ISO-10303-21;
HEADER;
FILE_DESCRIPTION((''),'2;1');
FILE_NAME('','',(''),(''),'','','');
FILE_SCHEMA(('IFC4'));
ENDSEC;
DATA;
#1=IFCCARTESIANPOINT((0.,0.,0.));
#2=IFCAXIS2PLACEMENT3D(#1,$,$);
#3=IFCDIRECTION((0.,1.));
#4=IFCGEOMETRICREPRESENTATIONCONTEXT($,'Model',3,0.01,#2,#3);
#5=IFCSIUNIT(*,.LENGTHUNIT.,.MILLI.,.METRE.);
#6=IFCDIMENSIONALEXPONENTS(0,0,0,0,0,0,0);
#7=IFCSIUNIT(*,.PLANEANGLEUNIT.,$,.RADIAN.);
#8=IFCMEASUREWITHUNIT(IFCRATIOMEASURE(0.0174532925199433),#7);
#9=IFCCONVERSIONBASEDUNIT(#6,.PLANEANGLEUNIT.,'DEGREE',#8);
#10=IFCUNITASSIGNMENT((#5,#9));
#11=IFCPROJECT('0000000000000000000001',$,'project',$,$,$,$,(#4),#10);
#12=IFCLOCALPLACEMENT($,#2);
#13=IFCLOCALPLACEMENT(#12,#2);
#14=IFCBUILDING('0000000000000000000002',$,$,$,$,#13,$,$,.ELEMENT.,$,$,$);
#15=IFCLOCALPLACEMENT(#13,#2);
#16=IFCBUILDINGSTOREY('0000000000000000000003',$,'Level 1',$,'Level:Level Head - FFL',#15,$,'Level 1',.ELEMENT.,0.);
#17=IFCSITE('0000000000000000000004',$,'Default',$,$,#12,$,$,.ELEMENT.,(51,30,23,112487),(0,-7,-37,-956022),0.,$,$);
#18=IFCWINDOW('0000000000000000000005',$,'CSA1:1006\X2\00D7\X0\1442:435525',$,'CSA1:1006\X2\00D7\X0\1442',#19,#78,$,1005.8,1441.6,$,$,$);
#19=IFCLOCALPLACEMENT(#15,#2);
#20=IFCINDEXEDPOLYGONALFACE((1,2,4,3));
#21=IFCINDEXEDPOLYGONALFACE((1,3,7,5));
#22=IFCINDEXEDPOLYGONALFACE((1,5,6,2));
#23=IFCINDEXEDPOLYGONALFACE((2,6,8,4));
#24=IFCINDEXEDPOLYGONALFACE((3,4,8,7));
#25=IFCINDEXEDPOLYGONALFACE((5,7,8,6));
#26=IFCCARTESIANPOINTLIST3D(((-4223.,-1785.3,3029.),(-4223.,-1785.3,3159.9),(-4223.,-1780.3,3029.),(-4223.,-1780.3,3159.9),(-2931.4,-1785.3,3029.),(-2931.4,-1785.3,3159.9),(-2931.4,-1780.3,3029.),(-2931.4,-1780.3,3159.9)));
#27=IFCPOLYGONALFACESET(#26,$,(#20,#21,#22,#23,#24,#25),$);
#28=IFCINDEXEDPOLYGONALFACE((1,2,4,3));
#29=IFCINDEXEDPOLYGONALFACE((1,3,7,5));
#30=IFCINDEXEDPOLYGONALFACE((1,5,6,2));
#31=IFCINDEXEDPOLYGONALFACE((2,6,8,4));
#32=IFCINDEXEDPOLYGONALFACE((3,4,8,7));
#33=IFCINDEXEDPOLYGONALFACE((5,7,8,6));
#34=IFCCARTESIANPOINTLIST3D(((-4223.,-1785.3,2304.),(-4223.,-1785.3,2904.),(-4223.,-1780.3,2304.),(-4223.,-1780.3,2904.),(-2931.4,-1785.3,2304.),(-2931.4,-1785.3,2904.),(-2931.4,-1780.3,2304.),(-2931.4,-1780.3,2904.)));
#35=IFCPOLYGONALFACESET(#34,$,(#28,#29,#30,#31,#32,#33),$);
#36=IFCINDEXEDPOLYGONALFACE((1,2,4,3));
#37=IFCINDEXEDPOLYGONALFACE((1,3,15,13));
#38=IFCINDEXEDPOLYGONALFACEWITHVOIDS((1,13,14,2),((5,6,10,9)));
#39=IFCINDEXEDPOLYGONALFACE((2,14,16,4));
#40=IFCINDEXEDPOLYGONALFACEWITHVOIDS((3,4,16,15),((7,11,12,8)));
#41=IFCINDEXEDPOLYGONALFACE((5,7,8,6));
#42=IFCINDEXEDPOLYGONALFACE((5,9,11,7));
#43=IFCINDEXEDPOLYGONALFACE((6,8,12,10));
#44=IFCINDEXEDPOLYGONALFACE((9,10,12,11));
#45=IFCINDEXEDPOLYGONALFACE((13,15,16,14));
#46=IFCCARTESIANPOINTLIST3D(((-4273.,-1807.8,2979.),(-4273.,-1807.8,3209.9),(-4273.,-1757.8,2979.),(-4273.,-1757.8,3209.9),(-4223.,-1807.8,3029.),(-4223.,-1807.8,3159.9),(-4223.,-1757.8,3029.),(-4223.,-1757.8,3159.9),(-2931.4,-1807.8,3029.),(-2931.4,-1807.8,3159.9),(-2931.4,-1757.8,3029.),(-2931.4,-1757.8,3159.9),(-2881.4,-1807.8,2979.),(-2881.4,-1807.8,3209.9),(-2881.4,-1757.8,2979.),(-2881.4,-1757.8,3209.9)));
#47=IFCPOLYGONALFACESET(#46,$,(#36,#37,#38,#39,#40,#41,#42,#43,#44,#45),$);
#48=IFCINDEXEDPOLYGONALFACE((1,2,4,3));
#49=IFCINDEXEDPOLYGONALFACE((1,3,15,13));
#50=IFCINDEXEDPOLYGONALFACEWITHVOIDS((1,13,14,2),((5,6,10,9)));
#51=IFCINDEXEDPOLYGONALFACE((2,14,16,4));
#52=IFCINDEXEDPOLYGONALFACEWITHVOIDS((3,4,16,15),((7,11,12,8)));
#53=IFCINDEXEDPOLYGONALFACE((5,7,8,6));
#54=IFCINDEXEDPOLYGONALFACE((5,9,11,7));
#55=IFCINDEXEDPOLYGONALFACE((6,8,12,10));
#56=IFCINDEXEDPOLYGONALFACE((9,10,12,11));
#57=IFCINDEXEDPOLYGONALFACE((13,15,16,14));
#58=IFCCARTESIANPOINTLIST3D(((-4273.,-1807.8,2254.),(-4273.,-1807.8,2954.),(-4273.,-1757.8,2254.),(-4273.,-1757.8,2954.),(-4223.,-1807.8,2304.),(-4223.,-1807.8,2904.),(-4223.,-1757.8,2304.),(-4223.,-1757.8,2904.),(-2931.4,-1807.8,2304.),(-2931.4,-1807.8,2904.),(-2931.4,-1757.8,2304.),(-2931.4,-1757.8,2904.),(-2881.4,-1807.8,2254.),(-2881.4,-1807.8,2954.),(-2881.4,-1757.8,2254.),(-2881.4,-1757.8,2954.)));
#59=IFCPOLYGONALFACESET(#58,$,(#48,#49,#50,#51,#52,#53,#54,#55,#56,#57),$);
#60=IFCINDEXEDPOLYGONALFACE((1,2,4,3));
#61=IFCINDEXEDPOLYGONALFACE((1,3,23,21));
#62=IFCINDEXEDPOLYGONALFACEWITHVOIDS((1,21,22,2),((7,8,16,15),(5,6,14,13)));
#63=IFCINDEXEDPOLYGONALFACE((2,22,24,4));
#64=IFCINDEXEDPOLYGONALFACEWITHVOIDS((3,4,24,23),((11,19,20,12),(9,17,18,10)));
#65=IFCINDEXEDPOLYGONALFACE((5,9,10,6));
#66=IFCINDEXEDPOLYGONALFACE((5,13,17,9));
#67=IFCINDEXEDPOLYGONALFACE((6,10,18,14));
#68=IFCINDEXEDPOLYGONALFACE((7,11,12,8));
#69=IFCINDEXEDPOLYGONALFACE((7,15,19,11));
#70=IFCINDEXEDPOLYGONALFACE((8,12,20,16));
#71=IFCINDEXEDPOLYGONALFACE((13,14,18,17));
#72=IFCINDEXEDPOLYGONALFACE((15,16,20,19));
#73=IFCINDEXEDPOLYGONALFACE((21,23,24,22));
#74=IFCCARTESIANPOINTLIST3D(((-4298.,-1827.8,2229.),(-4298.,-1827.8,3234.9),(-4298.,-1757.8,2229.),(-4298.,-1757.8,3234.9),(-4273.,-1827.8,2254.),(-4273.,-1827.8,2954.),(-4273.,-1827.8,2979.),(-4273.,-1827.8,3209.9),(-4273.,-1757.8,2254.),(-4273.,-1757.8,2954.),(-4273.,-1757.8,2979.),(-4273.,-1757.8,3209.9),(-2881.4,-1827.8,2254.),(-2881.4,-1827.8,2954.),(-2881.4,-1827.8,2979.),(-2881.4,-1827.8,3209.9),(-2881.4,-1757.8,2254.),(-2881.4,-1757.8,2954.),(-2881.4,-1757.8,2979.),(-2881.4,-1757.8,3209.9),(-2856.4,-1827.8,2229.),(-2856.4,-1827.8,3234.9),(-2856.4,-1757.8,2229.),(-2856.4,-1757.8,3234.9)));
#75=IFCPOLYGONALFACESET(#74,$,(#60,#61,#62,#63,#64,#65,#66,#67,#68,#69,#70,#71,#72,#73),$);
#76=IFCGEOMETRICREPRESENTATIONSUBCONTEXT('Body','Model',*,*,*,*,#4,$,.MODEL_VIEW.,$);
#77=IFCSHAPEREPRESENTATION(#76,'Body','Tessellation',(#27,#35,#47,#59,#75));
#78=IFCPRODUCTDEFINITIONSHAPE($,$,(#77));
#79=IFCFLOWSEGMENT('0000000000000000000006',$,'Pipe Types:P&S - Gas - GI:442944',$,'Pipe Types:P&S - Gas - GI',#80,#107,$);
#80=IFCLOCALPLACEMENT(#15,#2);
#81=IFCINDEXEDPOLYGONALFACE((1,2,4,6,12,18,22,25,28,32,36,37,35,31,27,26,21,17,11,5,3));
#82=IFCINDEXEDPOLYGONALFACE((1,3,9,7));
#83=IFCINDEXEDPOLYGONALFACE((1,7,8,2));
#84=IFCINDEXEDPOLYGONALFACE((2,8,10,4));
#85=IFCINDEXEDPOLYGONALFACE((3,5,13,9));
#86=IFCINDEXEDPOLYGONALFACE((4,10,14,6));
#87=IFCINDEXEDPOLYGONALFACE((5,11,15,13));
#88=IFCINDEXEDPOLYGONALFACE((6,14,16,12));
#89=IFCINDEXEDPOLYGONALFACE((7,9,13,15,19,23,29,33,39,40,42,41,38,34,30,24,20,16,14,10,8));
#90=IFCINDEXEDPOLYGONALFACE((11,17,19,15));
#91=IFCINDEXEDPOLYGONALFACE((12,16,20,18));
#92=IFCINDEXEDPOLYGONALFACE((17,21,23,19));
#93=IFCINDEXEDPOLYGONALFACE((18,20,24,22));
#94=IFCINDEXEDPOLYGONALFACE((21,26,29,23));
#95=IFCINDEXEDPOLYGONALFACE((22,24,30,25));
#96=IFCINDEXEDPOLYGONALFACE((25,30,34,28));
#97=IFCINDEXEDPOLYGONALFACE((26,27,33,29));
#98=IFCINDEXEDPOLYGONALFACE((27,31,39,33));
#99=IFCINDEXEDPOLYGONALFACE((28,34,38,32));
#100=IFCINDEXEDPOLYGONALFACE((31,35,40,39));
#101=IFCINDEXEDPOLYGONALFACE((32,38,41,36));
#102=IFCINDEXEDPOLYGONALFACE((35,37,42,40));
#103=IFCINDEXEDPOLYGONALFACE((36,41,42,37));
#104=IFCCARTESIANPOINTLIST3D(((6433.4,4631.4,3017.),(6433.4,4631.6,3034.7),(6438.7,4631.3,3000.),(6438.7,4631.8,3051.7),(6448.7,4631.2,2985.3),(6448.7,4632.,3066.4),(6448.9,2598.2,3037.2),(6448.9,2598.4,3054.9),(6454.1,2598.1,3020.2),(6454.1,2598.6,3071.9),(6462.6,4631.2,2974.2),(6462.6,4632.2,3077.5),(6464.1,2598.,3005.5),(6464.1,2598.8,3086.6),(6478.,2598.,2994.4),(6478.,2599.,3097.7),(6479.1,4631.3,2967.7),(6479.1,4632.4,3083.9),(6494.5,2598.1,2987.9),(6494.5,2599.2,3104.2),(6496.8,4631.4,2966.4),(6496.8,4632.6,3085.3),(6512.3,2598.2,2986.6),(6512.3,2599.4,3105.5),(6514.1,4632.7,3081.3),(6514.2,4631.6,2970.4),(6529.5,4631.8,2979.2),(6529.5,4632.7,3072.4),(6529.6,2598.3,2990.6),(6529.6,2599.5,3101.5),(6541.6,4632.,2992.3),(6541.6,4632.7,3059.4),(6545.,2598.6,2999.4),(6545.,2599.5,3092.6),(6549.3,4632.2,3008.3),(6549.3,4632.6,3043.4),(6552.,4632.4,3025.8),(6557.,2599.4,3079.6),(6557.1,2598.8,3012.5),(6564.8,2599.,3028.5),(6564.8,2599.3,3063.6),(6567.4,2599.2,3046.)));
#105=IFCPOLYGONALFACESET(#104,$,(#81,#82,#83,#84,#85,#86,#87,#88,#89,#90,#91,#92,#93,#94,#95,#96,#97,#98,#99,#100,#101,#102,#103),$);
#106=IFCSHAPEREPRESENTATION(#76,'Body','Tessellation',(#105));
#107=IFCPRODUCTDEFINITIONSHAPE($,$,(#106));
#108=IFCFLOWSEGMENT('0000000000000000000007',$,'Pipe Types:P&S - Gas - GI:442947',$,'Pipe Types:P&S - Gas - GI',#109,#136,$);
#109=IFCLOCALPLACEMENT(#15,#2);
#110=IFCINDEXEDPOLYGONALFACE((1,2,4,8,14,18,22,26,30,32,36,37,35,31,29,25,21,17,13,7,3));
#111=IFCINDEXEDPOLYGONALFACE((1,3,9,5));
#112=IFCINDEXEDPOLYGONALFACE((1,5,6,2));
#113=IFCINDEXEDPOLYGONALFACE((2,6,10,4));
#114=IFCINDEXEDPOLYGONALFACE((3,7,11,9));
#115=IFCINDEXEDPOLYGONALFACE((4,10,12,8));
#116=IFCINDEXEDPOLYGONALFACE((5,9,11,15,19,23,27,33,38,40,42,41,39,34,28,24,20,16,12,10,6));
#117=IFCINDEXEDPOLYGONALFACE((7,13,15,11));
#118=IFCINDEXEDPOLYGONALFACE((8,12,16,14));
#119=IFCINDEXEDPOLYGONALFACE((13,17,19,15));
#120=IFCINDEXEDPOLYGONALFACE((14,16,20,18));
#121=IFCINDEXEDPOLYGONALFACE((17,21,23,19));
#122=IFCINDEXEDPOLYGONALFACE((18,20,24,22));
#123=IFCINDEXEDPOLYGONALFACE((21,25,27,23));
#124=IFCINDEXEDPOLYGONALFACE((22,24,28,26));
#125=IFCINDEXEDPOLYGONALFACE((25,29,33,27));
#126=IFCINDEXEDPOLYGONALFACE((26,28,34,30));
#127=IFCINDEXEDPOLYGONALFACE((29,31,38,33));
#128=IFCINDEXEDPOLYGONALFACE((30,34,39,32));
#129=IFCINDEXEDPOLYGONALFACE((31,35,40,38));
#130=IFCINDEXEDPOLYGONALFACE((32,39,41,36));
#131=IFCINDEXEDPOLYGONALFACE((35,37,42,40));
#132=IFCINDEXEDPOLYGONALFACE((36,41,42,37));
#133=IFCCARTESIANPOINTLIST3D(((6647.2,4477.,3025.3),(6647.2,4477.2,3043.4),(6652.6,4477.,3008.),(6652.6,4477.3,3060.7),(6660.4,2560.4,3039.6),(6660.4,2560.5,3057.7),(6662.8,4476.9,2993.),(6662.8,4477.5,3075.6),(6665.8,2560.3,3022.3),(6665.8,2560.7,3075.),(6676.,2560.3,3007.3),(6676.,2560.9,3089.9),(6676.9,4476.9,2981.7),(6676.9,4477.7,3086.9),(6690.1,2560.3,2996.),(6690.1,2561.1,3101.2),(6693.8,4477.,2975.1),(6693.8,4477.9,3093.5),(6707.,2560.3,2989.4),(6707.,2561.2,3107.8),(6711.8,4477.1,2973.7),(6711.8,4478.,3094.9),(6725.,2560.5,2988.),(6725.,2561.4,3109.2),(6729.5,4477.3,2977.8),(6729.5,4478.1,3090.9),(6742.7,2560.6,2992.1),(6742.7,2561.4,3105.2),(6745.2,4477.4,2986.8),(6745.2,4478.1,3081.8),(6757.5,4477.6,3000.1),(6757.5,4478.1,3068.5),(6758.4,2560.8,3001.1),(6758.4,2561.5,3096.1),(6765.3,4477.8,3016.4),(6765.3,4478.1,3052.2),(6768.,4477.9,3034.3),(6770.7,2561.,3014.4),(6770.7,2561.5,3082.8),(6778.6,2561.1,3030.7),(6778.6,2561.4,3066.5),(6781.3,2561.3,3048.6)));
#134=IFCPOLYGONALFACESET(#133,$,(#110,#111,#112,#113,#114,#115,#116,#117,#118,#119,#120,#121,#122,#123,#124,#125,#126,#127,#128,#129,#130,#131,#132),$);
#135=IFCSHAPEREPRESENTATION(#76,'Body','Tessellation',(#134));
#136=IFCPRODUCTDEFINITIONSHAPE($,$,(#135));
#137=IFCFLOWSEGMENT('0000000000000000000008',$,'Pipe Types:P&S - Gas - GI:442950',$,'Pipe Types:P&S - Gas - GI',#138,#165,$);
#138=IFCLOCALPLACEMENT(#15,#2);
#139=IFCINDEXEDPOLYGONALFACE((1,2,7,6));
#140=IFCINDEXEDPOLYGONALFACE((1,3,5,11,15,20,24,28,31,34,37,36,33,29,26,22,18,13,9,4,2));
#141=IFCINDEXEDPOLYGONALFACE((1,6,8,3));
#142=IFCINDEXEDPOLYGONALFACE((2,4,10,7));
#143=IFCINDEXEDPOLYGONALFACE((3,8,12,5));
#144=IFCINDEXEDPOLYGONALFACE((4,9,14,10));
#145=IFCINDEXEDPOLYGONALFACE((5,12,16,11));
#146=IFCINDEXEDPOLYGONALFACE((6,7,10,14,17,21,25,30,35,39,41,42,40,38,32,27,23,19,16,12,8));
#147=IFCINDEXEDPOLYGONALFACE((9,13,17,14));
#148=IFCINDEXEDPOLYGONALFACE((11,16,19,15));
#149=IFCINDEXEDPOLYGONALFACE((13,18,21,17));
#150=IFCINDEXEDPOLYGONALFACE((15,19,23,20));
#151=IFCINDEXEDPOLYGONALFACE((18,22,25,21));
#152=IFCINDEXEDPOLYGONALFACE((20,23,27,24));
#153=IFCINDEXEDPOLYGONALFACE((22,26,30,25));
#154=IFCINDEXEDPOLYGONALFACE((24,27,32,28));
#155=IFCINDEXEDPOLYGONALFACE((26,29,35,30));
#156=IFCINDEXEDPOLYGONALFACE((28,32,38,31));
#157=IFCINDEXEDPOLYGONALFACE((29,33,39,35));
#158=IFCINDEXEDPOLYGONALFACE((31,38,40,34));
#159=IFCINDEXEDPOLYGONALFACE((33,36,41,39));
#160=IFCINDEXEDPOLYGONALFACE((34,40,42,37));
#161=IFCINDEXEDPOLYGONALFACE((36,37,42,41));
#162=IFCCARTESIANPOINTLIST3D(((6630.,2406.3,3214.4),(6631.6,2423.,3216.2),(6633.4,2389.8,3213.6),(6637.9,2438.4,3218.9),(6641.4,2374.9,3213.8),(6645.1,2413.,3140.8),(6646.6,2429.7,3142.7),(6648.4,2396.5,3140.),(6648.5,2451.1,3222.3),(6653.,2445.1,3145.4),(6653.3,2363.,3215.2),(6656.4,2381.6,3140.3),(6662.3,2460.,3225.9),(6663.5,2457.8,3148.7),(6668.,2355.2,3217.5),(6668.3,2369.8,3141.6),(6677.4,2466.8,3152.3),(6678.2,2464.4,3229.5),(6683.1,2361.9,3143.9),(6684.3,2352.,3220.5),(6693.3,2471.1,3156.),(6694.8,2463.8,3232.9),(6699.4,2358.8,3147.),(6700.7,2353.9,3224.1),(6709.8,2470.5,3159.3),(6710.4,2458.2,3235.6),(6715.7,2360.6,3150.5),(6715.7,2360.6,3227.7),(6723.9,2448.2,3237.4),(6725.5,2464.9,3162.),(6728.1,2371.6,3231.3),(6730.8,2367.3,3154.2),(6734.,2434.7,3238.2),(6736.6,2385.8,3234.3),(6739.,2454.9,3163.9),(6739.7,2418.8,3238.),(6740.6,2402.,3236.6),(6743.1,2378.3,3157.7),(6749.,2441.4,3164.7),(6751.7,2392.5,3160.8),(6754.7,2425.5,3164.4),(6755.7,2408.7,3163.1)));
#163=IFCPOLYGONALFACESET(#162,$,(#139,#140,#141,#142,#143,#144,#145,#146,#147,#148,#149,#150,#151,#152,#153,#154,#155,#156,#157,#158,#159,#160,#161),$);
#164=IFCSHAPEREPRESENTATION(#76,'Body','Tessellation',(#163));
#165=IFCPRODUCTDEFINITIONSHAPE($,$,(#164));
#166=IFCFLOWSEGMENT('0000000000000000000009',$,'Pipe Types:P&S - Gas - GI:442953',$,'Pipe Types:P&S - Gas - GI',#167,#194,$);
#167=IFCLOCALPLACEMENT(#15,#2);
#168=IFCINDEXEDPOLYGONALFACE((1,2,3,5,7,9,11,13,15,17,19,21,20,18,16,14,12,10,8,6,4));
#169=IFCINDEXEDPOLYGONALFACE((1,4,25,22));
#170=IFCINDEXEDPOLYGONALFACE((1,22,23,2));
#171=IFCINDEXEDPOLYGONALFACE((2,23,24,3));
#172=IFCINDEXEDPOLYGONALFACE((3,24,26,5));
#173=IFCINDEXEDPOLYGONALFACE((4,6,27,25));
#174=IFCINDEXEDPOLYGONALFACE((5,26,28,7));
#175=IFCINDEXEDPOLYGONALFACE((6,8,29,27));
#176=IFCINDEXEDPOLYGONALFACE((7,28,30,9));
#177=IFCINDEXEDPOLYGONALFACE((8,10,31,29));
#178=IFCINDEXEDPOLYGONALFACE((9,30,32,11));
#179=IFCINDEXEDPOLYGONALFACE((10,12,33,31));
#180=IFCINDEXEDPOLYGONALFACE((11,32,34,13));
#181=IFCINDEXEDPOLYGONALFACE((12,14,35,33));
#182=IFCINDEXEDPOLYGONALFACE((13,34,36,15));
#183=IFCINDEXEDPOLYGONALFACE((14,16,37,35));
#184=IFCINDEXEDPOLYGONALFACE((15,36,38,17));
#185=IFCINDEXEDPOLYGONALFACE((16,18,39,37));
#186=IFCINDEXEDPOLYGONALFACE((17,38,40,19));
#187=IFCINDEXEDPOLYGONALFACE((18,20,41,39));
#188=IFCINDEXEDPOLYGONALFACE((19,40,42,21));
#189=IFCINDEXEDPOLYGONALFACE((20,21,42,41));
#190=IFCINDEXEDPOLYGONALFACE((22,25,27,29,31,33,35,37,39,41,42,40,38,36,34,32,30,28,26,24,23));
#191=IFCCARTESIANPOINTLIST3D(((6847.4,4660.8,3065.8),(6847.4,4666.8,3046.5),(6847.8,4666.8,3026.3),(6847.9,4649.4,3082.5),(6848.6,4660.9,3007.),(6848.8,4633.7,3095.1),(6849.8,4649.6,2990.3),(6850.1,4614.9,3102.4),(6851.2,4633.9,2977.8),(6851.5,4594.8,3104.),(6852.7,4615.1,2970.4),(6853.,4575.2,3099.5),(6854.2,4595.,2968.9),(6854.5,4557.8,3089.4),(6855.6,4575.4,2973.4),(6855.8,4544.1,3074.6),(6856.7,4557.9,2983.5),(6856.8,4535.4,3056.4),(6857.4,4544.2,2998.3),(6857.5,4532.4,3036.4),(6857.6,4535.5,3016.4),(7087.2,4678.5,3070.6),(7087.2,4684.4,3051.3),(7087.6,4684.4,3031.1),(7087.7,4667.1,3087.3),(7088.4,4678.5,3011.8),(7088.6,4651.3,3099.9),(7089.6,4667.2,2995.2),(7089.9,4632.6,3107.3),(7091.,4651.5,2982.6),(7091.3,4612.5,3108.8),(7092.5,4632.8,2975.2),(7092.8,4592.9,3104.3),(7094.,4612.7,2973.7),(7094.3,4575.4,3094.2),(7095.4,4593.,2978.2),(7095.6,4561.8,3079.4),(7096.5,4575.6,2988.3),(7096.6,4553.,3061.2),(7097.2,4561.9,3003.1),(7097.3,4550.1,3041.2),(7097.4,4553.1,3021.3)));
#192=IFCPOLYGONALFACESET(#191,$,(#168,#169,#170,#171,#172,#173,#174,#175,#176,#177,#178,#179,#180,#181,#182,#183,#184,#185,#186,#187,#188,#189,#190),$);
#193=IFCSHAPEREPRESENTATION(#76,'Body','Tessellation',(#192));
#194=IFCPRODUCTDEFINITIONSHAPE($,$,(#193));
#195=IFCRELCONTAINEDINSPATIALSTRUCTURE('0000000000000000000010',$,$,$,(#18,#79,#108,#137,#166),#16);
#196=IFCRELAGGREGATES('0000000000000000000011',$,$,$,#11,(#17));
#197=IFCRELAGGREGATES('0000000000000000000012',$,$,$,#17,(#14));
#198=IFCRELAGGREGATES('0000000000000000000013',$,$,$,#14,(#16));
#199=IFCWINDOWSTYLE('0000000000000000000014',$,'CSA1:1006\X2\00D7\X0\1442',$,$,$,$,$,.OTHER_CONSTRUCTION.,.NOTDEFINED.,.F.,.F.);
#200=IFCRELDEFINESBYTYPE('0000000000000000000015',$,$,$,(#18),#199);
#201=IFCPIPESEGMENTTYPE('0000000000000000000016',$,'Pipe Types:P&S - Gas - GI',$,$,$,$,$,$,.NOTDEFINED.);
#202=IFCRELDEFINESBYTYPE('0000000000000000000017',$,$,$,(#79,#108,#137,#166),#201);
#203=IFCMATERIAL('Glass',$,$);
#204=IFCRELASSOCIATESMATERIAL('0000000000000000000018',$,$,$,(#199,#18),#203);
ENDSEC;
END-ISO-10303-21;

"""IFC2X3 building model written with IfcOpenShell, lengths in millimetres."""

from ifc_helpers import new_model, entity, si_unit, converted_unit, direction, frame, frame_2d, origin, origin_2d_with_axis, place, context, subcontext, project, spatial, polyline, rectangle, circle, outline, extrude, source, transform, mapped, material, type_object, type_shapes, element, save


model = new_model("IFC2X3")

# Units and contexts
model_context = context("Model", 3, precision=0.01, world=origin(), true_north=direction((0.0, 1.0)))
body_context = subcontext(model_context, "Body", "Model", "MODEL_VIEW")
ifc_project = project(units=[si_unit("LENGTHUNIT", "METRE", prefix="MILLI"), converted_unit("PLANEANGLEUNIT", "DEGREE", entity("IfcRatioMeasure", 0.0174532925199433), si_unit("PLANEANGLEUNIT", "RADIAN"), dimensions=[0, 0, 0, 0, 0, 0, 0])], contexts=[model_context])

# Site, building, storey
site_placement = place(None, origin())
site = spatial("IfcSite", under=ifc_project, at=site_placement, Name="Default", CompositionType="ELEMENT", RefLatitude=(51, 30, 23, 112487), RefLongitude=(0, -7, -37, -956022), RefElevation=0.0)
building_placement = place(site_placement, origin())
building = spatial("IfcBuilding", under=site, at=building_placement, CompositionType="ELEMENT")
storey_placement = place(building_placement, origin())
storey = spatial("IfcBuildingStorey", under=building, at=storey_placement, Name="Level 1", ObjectType="Level:Level Head - FFL", LongName="Level 1", CompositionType="ELEMENT", Elevation=0.0)

# Window
ifc_material_1 = material(Name="Glass")
window_style_1 = type_object("IfcWindowStyle", Name="CSA1:1006×1442", ConstructionType="OTHER_CONSTRUCTION", OperationType="NOTDEFINED", ParameterTakesPrecedence=False, Sizeable=False, material=ifc_material_1)
shared_shape_1 = source(origin(), body_context, "Body", "SweptSolid", [
    extrude(rectangle(XDim=5.0, YDim=1291.6, at=origin_2d_with_axis()), frame((720.8, 45.0, 800.0), z_axis=(0.0, 0.0, 1.0), x_axis=(0.0, 1.0, 0.0)), (0.0, 0.0, 1.0), 130.8),
    extrude(rectangle(XDim=5.0, YDim=1291.6, at=origin_2d_with_axis()), frame((720.8, 45.0, 75.0), z_axis=(0.0, 0.0, 1.0), x_axis=(0.0, 1.0, 0.0)), (0.0, 0.0, 1.0), 600.0),
    extrude(outline(polyline([(-695.8, -115.4), (695.8, -115.4), (695.8, 115.4), (-695.8, 115.4), (-695.8, -115.4)]), holes=[polyline([(-645.8, -65.4), (-645.8, 65.4), (645.8, 65.4), (645.8, -65.4), (-645.8, -65.4)])]), frame((720.8, 20.0, 865.4), z_axis=(0.0, 1.0, 0.0), x_axis=(1.0, 0.0, 0.0)), (0.0, 0.0, 1.0), 50.0),
    extrude(outline(polyline([(-695.8, -350.0), (695.8, -350.0), (695.8, 350.0), (-695.8, 350.0), (-695.8, -350.0)]), holes=[polyline([(-645.8, -300.0), (-645.8, 300.0), (645.8, 300.0), (645.8, -300.0), (-645.8, -300.0)])]), frame((720.8, 20.0, 375.0), z_axis=(0.0, 1.0, 0.0), x_axis=(1.0, 0.0, 0.0)), (0.0, 0.0, 1.0), 50.0),
    extrude(outline(polyline([(-720.8, -502.9), (720.8, -502.9), (720.8, 502.9), (-720.8, 502.9), (-720.8, -502.9)]), holes=[polyline([(-695.8, -477.9), (-695.8, -247.1), (695.8, -247.1), (695.8, -477.9), (-695.8, -477.9)]), polyline([(-695.8, -222.1), (-695.8, 477.9), (695.8, 477.9), (695.8, -222.1), (-695.8, -222.1)])]), frame((720.8, 0.0, 502.9), z_axis=(0.0, 1.0, 0.0), x_axis=(1.0, 0.0, 0.0)), (0.0, 0.0, 1.0), 70.0),
])
type_shapes(window_style_1, [shared_shape_1])
window_1_placement = place(storey_placement, frame((-4298.0, -1827.8, 2229.0)))
element("IfcWindow", 1, at=window_1_placement, inside=storey, type_object=window_style_1, material=ifc_material_1, Name="CSA1:1006×1442:435525", ObjectType="CSA1:1006×1442", OverallHeight=1005.8, OverallWidth=1441.6, context=body_context, shape_type="MappedRepresentation", body=[
    mapped(shared_shape_1, transform((0.0, 0.0, 0.0), scale=1.0)),
])

# Flow segments
pipe_segment_type = type_object("IfcPipeSegmentType", Name="Pipe Types:P&S - Gas - GI", PredefinedType="NOTDEFINED")
flow_segment_1_placement = place(storey_placement, origin())
element("IfcFlowSegment", 2, at=flow_segment_1_placement, inside=storey, type_object=pipe_segment_type, Name="Pipe Types:P&S - Gas - GI:442944", ObjectType="Pipe Types:P&S - Gas - GI", context=body_context, shape_type="SweptSolid", body=[
    extrude(circle(Radius=59.6, at=origin_2d_with_axis()), frame((6492.4, 4631.9, 3025.8), z_axis=(0.007586, -0.999922, 0.009936), x_axis=(0.999971, 0.007586, 0.0)), (0.0, 0.0, 1.0), 2033.4),
])
flow_segment_2_placement = place(storey_placement, origin())
element("IfcFlowSegment", 3, at=flow_segment_2_placement, inside=storey, type_object=pipe_segment_type, Name="Pipe Types:P&S - Gas - GI:442947", ObjectType="Pipe Types:P&S - Gas - GI", context=body_context, shape_type="SweptSolid", body=[
    extrude(circle(Radius=60.7, at=frame_2d((0.0, 0.0), x_axis=(1.0, 0.0))), frame((6707.3, 4477.5, 3034.3), z_axis=(0.006893, -0.999948, 0.007467), x_axis=(0.999976, 0.006893, 0.0)), (0.0, 0.0, 1.0), 1916.8),
])
flow_segment_3_placement = place(storey_placement, origin())
element("IfcFlowSegment", 4, at=flow_segment_3_placement, inside=storey, type_object=pipe_segment_type, Name="Pipe Types:P&S - Gas - GI:442950", ObjectType="Pipe Types:P&S - Gas - GI", context=body_context, shape_type="SweptSolid", body=[
    extrude(circle(Radius=56.6, at=frame_2d((0.0, 0.0), x_axis=(1.0, 0.0))), frame((6700.4, 2415.1, 3152.3), z_axis=(-0.199531, -0.089078, 0.975834), x_axis=(-0.407656, 0.913135, 0.0)), (0.0, 0.0, 1.0), 75.4),
])
flow_segment_4_placement = place(storey_placement, origin())
element("IfcFlowSegment", 5, at=flow_segment_4_placement, inside=storey, type_object=pipe_segment_type, Name="Pipe Types:P&S - Gas - GI:442953", ObjectType="Pipe Types:P&S - Gas - GI", context=body_context, shape_type="SweptSolid", body=[
    extrude(circle(Radius=67.7, at=frame_2d((0.0, 0.0), x_axis=(1.0, 0.0))), frame((6852.5, 4600.0, 3036.4), z_axis=(0.997105, 0.073345, 0.020056), x_axis=(0.073359, -0.997306, 0.0)), (0.0, 0.0, 1.0), 240.5),
])

save(model, "model.ifc")
